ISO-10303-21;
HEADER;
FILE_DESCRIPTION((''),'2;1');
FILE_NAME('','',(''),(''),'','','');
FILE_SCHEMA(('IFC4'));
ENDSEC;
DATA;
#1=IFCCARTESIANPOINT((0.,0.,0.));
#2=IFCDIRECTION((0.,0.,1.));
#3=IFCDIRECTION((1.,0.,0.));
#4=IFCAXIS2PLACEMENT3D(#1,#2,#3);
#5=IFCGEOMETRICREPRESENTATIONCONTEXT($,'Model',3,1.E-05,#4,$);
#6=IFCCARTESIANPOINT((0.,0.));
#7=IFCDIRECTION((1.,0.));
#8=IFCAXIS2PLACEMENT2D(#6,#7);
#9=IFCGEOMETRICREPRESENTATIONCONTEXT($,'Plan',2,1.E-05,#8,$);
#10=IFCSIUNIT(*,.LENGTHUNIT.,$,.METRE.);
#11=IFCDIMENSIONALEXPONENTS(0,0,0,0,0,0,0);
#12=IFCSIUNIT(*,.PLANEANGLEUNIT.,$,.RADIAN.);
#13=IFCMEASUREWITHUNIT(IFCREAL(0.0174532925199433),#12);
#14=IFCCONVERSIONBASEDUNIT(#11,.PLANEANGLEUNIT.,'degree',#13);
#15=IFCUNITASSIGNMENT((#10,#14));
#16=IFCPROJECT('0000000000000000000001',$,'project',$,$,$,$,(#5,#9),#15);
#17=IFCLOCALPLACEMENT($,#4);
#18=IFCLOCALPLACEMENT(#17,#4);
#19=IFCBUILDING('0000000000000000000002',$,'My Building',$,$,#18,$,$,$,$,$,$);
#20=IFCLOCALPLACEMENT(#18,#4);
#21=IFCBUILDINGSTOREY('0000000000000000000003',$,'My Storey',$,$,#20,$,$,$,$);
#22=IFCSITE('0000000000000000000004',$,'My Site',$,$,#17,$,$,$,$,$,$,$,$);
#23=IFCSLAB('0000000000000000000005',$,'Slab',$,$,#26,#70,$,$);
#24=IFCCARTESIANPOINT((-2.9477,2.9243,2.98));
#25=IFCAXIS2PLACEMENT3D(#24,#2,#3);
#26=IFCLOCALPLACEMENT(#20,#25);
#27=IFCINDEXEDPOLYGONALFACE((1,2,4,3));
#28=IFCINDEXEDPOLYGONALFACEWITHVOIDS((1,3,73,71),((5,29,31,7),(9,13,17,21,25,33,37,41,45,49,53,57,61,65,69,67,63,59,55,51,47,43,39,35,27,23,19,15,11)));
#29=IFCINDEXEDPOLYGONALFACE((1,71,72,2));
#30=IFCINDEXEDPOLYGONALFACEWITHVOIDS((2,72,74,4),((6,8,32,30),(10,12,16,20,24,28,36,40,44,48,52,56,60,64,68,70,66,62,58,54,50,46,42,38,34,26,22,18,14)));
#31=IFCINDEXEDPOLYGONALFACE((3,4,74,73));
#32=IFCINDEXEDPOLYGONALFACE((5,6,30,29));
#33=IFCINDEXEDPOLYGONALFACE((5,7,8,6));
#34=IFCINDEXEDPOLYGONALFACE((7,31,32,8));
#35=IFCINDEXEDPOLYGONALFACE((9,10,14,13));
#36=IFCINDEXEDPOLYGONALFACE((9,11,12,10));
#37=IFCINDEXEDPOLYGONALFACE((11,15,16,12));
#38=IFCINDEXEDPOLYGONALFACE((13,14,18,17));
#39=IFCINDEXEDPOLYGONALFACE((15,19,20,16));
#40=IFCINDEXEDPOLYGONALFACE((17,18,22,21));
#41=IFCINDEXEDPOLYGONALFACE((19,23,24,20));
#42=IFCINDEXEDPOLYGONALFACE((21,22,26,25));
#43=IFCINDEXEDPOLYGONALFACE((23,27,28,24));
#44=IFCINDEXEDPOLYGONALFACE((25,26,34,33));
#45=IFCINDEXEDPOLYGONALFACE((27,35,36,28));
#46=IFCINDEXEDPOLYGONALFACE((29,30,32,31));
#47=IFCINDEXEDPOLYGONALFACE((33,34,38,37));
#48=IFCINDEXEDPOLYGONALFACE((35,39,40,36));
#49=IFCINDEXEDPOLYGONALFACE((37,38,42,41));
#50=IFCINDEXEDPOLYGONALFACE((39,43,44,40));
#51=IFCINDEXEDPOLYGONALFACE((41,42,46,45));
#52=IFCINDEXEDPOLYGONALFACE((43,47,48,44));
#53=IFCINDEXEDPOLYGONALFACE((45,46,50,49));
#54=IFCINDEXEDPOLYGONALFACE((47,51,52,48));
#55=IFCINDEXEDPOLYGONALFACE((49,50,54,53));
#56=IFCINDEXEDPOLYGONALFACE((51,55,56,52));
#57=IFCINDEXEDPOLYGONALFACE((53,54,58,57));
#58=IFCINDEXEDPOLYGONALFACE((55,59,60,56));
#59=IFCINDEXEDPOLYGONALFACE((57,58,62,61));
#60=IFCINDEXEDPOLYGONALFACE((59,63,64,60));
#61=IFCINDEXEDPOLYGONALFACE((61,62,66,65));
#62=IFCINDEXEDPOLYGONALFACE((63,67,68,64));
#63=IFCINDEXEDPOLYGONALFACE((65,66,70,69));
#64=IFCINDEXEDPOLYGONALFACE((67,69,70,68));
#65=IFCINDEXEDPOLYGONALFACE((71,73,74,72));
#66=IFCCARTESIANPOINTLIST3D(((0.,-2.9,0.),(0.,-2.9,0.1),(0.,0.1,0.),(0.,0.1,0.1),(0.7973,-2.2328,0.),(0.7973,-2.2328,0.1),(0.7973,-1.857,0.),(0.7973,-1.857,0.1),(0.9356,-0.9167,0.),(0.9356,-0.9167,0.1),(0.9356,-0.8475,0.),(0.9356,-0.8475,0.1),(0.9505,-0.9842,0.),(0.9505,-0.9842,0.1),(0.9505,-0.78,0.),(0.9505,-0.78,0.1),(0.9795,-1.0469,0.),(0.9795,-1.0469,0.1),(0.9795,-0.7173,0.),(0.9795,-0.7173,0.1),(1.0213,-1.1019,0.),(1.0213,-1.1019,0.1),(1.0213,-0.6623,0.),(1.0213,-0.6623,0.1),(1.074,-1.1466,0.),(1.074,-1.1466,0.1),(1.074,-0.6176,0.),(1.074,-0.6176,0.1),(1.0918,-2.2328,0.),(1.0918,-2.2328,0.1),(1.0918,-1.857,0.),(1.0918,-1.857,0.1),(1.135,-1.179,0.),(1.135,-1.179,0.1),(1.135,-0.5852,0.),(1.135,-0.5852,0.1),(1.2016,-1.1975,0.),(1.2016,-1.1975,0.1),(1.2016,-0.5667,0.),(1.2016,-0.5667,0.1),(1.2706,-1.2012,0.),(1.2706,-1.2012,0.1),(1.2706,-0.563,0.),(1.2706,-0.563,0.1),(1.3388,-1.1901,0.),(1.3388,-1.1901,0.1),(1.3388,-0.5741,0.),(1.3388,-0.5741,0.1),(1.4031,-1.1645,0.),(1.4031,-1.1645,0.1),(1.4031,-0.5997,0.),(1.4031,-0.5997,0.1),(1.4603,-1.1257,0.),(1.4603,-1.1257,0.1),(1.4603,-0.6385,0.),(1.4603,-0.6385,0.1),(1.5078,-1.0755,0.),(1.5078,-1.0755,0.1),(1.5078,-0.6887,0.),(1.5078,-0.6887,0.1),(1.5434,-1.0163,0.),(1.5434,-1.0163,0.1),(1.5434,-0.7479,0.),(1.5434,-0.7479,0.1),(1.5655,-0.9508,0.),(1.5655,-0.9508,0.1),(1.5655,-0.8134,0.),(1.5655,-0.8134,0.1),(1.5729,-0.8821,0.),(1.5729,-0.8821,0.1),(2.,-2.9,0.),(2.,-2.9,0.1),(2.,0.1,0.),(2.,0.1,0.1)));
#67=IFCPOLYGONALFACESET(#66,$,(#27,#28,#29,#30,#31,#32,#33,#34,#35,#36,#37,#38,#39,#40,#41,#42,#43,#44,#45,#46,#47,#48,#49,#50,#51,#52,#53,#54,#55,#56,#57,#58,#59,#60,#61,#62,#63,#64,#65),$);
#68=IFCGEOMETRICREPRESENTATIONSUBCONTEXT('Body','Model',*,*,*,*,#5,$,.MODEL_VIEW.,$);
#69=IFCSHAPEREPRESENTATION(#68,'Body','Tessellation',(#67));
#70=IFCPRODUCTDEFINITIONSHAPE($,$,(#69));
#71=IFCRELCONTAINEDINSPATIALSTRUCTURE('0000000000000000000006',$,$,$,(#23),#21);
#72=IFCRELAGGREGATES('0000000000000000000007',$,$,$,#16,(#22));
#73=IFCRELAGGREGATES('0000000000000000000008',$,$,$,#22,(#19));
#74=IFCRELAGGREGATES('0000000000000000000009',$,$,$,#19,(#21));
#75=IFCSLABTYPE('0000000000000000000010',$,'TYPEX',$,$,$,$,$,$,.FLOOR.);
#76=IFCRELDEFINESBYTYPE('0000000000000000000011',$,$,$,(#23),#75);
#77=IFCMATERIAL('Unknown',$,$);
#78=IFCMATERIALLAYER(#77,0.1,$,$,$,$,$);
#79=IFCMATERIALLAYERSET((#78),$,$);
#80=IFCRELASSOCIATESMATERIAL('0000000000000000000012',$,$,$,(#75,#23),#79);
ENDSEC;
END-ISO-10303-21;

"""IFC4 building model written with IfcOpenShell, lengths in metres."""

from ifc_helpers import new_model, entity, si_unit, converted_unit, frame, frame_2d, origin_with_axes, origin_2d_with_axis, place, context, subcontext, project, spatial, line, indexed_curve, circle_curve, outline, extrude, material, layer, layer_set, layer_usage, type_object, element, save


model = new_model("IFC4")

# Units and contexts
model_context = context("Model", 3, precision=1e-05, world=origin_with_axes())
plan_context = context("Plan", 2, precision=1e-05, world=origin_2d_with_axis())
body_context = subcontext(model_context, "Body", "Model", "MODEL_VIEW")
ifc_project = project(units=[si_unit("LENGTHUNIT", "METRE"), converted_unit("PLANEANGLEUNIT", "degree", entity("IfcReal", 0.0174532925199433), si_unit("PLANEANGLEUNIT", "RADIAN"), dimensions=[0, 0, 0, 0, 0, 0, 0])], contexts=[model_context, plan_context])

# Site, building, storey
site_placement = place(None, origin_with_axes())
site = spatial("IfcSite", under=ifc_project, at=site_placement, Name="My Site")
building_placement = place(site_placement, origin_with_axes())
building = spatial("IfcBuilding", under=site, at=building_placement, Name="My Building")
storey_placement = place(building_placement, origin_with_axes())
storey = spatial("IfcBuildingStorey", under=building, at=storey_placement, Name="My Storey")

# Shared definitions
ifc_material = material(Name="Unknown")

# Slab
ifc_layer_1 = layer(ifc_material, 0.1)
ifc_layer_set_1 = layer_set([ifc_layer_1])
ifc_layer_usage_1 = layer_usage(ifc_layer_set_1, "AXIS3", "POSITIVE", 0.0)
slab_type = type_object("IfcSlabType", Name="TYPEX", PredefinedType="FLOOR", material=ifc_layer_set_1)
slab_1_placement = place(storey_placement, frame((-2.9477, 2.9243, 2.98), z_axis=(0.0, 0.0, 1.0), x_axis=(1.0, 0.0, 0.0)))
element("IfcSlab", 1, at=slab_1_placement, inside=storey, type_object=slab_type, material=ifc_layer_usage_1, Name="Slab", context=body_context, shape_type="SweptSolid", body=[
    extrude(outline(indexed_curve([(2.0, -2.9), (2.0, 0.1), (0.0, 0.1), (0.0, -2.9), (0.7973, -2.2328), (1.0918, -2.2328), (1.0918, -1.857), (0.7973, -1.857), (1.2533, -1.2017), (1.2533, -0.5625)], segments=[line(4, 3), line(3, 2), line(2, 1), line(1, 4)], self_intersect=False), holes=[indexed_curve([(2.0, -2.9), (2.0, 0.1), (0.0, 0.1), (0.0, -2.9), (0.7973, -2.2328), (1.0918, -2.2328), (1.0918, -1.857), (0.7973, -1.857), (1.2533, -1.2017), (1.2533, -0.5625)], segments=[line(8, 7), line(7, 6), line(6, 5), line(5, 8)], self_intersect=False), circle_curve(frame_2d((1.2533, -0.8821)), 0.3196)]), None, (0.0, 0.0, 1.0), 0.1),
])

save(model, "model.ifc")
